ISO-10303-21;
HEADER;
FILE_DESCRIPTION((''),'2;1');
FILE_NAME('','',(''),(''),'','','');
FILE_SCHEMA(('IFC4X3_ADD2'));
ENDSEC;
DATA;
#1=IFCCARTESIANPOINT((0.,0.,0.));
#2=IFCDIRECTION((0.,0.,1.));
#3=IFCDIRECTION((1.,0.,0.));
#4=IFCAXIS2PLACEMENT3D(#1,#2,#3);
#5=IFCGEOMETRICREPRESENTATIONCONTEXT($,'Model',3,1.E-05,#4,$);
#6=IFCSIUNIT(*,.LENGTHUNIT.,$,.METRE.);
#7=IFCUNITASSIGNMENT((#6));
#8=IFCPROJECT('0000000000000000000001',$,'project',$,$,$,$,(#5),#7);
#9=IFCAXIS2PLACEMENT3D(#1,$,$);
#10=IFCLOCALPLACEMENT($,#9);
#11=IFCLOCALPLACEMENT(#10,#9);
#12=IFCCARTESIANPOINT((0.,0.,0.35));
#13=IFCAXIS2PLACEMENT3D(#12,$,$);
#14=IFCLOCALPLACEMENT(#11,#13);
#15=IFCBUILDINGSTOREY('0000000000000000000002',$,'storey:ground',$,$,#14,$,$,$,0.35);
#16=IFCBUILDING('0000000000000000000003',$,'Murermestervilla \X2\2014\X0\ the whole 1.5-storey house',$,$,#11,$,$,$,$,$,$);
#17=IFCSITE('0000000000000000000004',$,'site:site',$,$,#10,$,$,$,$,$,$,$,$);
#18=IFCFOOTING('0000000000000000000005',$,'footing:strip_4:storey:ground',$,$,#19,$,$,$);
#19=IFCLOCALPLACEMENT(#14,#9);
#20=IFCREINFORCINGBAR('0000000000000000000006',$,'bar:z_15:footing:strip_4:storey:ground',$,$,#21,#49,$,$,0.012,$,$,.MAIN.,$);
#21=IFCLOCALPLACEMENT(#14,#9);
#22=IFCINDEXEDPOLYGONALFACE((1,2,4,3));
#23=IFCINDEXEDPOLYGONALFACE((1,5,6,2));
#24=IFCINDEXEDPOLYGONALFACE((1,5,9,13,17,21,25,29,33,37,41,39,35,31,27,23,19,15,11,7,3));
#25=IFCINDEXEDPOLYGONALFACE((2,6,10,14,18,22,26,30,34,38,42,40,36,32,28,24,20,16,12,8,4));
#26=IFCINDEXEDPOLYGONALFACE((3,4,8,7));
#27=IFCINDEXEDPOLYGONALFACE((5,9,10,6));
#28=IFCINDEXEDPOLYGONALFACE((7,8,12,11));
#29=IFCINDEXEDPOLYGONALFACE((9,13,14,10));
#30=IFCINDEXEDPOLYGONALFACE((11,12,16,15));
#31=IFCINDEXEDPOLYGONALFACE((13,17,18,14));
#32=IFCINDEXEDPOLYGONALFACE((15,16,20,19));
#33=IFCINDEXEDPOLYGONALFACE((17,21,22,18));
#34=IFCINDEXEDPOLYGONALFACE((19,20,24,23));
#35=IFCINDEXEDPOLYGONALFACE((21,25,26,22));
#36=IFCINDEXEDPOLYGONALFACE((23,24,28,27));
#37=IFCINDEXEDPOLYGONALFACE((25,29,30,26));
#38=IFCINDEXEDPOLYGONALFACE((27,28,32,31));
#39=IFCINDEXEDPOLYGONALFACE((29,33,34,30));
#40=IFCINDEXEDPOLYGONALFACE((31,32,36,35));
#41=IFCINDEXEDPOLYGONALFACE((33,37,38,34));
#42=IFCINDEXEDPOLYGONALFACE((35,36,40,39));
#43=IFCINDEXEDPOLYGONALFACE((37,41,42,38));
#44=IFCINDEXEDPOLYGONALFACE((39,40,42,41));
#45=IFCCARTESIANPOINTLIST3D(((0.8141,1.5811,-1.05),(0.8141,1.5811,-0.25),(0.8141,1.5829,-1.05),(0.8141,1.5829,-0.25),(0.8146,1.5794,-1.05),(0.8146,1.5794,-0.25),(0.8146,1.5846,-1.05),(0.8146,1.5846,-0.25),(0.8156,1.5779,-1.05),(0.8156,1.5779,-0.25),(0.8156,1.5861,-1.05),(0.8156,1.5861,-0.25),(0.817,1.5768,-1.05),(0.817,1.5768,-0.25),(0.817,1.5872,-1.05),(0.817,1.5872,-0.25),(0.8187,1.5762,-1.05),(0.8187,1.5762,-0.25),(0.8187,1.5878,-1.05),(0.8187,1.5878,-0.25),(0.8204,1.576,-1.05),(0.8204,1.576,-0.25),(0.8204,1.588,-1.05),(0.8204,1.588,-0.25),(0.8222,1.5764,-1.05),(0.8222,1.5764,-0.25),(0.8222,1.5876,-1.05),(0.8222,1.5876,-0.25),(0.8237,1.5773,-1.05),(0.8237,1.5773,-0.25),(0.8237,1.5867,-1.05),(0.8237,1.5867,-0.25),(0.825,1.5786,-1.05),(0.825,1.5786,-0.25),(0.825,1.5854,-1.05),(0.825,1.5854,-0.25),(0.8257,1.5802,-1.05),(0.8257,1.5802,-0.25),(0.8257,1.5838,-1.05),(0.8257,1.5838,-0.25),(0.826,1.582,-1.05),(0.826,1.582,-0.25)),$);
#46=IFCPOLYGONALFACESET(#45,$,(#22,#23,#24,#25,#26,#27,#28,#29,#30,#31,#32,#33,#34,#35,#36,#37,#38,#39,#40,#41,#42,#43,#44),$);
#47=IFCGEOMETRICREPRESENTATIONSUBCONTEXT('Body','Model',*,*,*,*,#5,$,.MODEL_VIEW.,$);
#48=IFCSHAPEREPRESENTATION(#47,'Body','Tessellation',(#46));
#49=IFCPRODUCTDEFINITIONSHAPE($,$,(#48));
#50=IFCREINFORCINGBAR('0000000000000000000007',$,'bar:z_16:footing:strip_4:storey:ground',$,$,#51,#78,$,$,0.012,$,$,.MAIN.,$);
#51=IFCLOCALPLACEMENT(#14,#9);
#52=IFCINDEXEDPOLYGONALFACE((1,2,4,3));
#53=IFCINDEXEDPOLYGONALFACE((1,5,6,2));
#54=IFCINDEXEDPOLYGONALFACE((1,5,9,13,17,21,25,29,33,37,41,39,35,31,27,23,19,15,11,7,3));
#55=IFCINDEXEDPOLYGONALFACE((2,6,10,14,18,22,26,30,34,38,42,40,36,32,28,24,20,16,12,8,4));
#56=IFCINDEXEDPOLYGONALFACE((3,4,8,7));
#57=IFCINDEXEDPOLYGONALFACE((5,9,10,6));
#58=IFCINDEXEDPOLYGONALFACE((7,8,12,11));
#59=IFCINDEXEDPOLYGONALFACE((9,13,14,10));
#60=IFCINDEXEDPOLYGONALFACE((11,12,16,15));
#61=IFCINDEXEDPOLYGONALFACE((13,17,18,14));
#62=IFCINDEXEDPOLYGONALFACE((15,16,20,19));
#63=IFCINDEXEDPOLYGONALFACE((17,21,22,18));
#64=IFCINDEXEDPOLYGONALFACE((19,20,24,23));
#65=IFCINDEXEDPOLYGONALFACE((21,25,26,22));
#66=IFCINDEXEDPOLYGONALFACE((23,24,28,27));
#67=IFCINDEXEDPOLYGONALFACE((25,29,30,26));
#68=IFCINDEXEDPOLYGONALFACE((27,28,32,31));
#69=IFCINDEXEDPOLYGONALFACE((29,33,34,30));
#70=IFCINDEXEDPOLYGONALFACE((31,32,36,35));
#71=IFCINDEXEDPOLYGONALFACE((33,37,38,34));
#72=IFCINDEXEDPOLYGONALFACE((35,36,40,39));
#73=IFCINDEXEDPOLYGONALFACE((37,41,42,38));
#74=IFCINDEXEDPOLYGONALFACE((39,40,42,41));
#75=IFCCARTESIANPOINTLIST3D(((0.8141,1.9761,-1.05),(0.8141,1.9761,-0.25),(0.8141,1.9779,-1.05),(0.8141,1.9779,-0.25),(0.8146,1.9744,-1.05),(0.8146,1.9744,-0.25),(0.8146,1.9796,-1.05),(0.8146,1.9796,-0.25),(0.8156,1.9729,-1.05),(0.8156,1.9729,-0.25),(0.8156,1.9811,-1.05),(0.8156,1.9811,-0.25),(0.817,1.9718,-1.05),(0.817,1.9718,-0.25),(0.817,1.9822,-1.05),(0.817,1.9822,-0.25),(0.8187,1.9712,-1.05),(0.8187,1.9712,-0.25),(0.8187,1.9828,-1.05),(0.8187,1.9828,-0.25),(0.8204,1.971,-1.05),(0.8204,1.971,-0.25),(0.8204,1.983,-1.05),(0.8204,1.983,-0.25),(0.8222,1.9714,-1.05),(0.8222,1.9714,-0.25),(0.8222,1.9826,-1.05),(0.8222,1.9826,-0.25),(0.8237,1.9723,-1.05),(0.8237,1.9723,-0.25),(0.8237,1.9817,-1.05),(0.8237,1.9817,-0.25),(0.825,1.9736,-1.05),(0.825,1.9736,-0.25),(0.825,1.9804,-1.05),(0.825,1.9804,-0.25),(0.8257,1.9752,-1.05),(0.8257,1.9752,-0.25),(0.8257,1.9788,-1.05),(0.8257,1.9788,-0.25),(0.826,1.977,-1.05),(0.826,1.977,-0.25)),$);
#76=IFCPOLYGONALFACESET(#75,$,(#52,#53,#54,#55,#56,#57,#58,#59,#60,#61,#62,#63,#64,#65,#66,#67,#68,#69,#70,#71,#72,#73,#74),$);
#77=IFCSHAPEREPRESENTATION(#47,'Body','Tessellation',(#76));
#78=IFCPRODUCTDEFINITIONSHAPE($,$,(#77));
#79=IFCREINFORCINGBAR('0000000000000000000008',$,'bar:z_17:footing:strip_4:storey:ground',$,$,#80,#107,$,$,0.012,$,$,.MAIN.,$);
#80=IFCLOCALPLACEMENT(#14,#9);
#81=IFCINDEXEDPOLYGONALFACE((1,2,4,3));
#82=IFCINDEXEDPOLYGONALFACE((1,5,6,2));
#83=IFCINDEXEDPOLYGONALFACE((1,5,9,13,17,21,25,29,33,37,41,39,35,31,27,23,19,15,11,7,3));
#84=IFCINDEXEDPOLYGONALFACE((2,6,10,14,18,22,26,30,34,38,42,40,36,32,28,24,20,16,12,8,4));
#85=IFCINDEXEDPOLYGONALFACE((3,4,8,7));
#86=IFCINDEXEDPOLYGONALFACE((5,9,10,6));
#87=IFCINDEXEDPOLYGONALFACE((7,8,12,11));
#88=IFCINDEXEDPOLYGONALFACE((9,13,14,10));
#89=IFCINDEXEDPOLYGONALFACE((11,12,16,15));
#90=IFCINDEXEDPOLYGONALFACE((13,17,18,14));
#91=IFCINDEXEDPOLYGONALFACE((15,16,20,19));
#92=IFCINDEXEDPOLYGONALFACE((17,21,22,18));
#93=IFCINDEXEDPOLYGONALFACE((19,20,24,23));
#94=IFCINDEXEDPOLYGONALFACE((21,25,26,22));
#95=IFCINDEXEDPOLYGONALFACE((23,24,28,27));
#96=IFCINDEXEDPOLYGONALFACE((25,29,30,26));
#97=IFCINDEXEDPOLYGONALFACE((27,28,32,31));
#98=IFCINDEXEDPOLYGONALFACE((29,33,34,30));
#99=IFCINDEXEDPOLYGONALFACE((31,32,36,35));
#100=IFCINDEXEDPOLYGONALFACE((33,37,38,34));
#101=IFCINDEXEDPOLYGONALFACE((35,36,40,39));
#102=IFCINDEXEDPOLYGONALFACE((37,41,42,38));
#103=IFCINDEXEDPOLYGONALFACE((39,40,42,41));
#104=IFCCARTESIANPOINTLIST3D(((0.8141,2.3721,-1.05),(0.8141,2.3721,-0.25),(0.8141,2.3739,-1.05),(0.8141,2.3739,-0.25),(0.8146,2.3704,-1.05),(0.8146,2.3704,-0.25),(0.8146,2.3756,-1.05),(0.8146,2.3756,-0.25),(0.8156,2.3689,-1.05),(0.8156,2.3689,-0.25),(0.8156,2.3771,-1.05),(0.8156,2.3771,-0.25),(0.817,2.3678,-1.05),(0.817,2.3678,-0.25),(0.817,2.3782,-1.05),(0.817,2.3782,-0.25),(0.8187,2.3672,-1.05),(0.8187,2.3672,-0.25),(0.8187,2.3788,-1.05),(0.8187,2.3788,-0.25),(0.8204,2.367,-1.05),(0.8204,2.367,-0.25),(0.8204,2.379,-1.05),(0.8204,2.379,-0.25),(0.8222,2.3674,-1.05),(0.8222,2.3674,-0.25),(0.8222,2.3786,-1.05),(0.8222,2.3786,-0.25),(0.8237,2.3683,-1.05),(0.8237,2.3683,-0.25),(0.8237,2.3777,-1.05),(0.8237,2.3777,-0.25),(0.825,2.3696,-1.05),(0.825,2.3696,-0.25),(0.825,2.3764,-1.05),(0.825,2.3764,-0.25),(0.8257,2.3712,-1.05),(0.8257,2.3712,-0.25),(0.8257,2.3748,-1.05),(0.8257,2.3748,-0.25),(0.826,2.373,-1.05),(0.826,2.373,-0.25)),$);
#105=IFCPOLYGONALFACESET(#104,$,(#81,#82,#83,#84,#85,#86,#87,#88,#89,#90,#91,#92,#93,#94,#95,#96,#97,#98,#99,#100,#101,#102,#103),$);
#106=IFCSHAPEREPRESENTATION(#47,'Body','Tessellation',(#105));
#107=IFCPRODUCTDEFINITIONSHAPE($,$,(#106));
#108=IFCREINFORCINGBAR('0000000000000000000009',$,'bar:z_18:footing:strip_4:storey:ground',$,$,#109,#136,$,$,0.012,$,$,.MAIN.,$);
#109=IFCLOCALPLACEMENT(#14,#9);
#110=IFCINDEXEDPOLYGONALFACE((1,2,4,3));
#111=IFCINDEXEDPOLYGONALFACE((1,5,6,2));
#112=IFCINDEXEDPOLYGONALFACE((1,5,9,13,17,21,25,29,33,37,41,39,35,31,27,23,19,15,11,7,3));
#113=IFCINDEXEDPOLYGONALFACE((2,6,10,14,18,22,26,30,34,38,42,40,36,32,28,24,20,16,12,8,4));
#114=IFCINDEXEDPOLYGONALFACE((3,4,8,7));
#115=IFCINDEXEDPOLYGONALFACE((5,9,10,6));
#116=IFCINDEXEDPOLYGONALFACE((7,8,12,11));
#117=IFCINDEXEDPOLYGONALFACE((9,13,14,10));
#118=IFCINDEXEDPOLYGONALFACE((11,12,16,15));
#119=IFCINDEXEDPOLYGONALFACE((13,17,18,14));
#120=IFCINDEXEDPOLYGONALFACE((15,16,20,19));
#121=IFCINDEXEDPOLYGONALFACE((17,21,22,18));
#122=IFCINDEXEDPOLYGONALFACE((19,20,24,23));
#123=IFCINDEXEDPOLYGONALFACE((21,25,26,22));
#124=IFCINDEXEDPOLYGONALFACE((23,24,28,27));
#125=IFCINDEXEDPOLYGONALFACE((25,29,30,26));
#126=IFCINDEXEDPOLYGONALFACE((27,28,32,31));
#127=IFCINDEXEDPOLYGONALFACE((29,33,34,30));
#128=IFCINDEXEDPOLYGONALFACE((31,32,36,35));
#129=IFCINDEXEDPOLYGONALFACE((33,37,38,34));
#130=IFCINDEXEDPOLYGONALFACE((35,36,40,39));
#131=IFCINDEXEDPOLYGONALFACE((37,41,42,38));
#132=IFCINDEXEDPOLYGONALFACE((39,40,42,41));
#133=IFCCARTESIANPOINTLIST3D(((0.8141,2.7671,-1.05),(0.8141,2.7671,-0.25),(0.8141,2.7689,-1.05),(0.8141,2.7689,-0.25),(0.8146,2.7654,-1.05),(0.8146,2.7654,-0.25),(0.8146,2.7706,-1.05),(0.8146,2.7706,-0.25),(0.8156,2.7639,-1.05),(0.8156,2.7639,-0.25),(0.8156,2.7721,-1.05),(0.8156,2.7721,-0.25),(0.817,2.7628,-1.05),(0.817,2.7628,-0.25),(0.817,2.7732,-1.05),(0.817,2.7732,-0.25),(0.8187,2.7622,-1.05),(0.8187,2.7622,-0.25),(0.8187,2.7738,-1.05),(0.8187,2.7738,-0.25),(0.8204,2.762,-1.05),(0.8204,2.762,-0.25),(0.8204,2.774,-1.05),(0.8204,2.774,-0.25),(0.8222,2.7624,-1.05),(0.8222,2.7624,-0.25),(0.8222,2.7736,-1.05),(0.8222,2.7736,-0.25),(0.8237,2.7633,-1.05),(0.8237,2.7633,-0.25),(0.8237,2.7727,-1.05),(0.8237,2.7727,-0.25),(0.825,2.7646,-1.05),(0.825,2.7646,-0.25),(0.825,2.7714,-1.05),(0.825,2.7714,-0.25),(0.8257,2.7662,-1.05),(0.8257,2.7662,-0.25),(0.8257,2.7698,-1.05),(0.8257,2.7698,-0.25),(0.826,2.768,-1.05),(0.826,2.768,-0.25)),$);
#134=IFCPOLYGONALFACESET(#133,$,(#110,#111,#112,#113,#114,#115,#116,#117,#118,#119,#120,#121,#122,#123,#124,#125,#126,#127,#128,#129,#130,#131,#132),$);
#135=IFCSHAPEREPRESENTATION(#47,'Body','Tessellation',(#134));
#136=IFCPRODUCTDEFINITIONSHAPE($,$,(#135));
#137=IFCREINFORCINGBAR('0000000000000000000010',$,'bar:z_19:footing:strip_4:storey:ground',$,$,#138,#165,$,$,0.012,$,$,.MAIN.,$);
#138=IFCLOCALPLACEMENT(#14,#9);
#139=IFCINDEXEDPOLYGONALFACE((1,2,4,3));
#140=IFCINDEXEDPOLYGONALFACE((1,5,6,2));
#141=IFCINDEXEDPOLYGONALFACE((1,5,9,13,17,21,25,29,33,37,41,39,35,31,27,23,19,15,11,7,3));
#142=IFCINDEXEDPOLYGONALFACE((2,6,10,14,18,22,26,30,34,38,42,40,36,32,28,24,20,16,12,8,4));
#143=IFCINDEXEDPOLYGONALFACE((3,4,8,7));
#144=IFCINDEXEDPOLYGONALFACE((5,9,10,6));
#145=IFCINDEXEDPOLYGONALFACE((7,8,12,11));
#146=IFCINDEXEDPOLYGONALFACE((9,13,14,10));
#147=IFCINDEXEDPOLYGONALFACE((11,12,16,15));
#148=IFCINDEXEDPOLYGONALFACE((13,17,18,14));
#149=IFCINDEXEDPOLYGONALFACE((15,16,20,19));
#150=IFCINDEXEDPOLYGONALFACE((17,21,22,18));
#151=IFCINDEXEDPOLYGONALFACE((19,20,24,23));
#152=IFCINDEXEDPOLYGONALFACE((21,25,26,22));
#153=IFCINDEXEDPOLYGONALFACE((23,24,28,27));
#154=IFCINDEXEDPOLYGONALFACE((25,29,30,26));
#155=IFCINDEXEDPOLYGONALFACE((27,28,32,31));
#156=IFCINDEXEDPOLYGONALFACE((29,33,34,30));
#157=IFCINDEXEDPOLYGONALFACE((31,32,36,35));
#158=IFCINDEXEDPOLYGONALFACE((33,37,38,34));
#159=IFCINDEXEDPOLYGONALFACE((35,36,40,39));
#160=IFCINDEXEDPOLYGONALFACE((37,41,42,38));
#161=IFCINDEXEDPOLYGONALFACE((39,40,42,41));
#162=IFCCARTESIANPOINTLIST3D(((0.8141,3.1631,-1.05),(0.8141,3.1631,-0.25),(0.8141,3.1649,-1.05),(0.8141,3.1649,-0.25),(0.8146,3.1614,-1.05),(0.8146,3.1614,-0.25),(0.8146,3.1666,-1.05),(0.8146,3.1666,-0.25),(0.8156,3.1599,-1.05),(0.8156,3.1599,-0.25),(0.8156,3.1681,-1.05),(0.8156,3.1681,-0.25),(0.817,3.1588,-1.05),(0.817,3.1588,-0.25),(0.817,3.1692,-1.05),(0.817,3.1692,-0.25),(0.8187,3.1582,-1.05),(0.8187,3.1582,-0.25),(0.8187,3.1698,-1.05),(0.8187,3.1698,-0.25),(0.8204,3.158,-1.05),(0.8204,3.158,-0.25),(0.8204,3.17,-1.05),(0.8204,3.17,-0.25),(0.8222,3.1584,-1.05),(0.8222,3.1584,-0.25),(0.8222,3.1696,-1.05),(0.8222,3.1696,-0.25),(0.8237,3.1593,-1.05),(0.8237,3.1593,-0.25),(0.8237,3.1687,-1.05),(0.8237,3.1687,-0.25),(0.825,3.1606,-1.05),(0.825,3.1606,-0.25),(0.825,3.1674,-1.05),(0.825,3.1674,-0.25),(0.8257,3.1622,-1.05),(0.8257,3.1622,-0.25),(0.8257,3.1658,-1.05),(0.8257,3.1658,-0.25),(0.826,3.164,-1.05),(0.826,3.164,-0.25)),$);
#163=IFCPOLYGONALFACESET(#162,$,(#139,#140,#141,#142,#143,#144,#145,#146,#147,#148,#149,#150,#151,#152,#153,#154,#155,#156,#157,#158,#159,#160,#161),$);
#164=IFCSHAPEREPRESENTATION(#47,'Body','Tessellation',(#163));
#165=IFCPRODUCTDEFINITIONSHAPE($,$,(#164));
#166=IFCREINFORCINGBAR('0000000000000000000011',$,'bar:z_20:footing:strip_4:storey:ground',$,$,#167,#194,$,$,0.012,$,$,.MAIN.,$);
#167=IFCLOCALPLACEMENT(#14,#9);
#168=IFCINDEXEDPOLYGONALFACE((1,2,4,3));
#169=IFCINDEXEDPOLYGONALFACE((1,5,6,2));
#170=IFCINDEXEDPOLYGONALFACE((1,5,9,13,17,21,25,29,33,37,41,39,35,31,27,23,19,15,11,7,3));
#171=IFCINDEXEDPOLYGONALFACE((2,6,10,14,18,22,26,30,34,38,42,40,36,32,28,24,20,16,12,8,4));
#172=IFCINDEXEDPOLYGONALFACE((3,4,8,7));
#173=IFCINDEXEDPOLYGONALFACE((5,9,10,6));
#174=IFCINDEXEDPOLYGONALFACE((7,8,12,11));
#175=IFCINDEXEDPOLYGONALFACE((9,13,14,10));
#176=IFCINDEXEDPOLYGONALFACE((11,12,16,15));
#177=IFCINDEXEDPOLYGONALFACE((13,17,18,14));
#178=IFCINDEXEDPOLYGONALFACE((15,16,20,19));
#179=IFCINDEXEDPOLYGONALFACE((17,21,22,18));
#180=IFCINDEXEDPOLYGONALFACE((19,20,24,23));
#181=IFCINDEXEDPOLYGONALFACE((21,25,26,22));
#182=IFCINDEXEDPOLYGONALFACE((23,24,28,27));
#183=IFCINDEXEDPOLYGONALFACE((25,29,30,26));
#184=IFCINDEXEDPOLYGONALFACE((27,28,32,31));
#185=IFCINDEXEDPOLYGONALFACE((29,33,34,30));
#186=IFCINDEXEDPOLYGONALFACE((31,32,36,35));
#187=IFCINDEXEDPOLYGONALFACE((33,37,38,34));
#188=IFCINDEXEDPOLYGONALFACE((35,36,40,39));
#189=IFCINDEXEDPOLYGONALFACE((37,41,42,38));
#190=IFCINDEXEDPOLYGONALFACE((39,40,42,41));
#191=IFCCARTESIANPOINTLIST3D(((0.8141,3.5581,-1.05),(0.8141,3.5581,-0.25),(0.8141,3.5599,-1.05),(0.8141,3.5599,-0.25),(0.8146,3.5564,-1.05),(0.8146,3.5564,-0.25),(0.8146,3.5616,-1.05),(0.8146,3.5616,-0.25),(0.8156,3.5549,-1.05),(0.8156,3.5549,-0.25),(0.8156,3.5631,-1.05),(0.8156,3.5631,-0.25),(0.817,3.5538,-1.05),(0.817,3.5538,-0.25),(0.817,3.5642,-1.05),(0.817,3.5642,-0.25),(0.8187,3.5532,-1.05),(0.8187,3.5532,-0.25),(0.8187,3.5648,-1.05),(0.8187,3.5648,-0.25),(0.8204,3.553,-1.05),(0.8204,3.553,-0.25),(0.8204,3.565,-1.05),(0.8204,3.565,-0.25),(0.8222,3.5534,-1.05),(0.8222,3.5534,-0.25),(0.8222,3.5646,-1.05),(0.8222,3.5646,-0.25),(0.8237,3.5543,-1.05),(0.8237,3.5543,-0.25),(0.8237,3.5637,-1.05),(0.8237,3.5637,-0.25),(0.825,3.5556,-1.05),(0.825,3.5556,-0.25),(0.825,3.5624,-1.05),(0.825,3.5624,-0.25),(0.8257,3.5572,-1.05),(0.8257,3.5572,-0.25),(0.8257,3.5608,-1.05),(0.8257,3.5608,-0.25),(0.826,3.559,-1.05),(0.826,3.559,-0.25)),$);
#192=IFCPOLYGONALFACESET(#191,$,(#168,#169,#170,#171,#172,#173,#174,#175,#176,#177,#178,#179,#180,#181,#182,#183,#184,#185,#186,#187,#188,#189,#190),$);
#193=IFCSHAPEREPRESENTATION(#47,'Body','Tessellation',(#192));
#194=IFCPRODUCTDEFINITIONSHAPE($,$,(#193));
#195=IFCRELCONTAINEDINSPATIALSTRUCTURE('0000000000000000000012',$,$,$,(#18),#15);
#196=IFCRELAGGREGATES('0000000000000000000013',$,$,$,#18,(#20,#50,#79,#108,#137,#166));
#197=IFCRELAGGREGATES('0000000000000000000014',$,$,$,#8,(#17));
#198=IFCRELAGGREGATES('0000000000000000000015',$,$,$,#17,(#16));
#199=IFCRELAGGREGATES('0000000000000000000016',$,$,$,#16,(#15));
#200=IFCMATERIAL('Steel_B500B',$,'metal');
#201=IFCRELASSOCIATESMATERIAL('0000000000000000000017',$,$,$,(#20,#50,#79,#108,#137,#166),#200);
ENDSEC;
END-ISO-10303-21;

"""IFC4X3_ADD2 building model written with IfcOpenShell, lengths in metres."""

from ifc_helpers import new_model, entity, si_unit, frame, origin, origin_with_axes, place, context, subcontext, project, spatial, material, element, aggregate, save


model = new_model("IFC4X3_ADD2")

# Units and contexts
model_context = context("Model", 3, precision=1e-05, world=origin_with_axes())
body_context = subcontext(model_context, "Body", "Model", "MODEL_VIEW")
ifc_project = project(units=[si_unit("LENGTHUNIT", "METRE")], contexts=[model_context])

# Site, building, storey
placement_1 = place(None, origin())
site = spatial("IfcSite", under=ifc_project, at=placement_1, Name="site:site")
building_placement = place(placement_1, origin())
building = spatial("IfcBuilding", under=site, at=building_placement, Name="Murermestervilla — the whole 1.5-storey house")
storey_placement = place(building_placement, frame((0.0, 0.0, 0.35)))
storey = spatial("IfcBuildingStorey", under=building, at=storey_placement, Name="storey:ground", Elevation=0.35)

# Footing, reinforcing bars
placement_2 = place(storey_placement, frame((0.0, 0.0, -0.35)))
footing_1 = element("IfcFooting", 1, at=placement_2, inside=storey, Name="footing:strip_4:storey:ground")
ifc_material = material(Name="Steel_B500B", Category="metal")
reinforcing_bar_1 = element("IfcReinforcingBar", 2, at=placement_1, material=ifc_material, Name="bar:z_15:footing:strip_4:storey:ground", NominalDiameter=0.012, PredefinedType="MAIN", context=body_context, shape_type="AdvancedSweptSolid", body=[
    entity("IfcSweptDiskSolid", entity("IfcPolyline", [entity("IfcCartesianPoint", [0.82, 1.582, -0.7]), entity("IfcCartesianPoint", [0.82, 1.582, 0.1])]), 0.006),
])
reinforcing_bar_2 = element("IfcReinforcingBar", 3, at=placement_1, material=ifc_material, Name="bar:z_16:footing:strip_4:storey:ground", NominalDiameter=0.012, PredefinedType="MAIN", context=body_context, shape_type="AdvancedSweptSolid", body=[
    entity("IfcSweptDiskSolid", entity("IfcPolyline", [entity("IfcCartesianPoint", [0.82, 1.977, -0.7]), entity("IfcCartesianPoint", [0.82, 1.977, 0.1])]), 0.006),
])
reinforcing_bar_3 = element("IfcReinforcingBar", 4, at=placement_1, material=ifc_material, Name="bar:z_17:footing:strip_4:storey:ground", NominalDiameter=0.012, PredefinedType="MAIN", context=body_context, shape_type="AdvancedSweptSolid", body=[
    entity("IfcSweptDiskSolid", entity("IfcPolyline", [entity("IfcCartesianPoint", [0.82, 2.373, -0.7]), entity("IfcCartesianPoint", [0.82, 2.373, 0.1])]), 0.006),
])
reinforcing_bar_4 = element("IfcReinforcingBar", 5, at=placement_1, material=ifc_material, Name="bar:z_18:footing:strip_4:storey:ground", NominalDiameter=0.012, PredefinedType="MAIN", context=body_context, shape_type="AdvancedSweptSolid", body=[
    entity("IfcSweptDiskSolid", entity("IfcPolyline", [entity("IfcCartesianPoint", [0.82, 2.768, -0.7]), entity("IfcCartesianPoint", [0.82, 2.768, 0.1])]), 0.006),
])
reinforcing_bar_5 = element("IfcReinforcingBar", 6, at=placement_1, material=ifc_material, Name="bar:z_19:footing:strip_4:storey:ground", NominalDiameter=0.012, PredefinedType="MAIN", context=body_context, shape_type="AdvancedSweptSolid", body=[
    entity("IfcSweptDiskSolid", entity("IfcPolyline", [entity("IfcCartesianPoint", [0.82, 3.164, -0.7]), entity("IfcCartesianPoint", [0.82, 3.164, 0.1])]), 0.006),
])
reinforcing_bar_6 = element("IfcReinforcingBar", 7, at=placement_1, material=ifc_material, Name="bar:z_20:footing:strip_4:storey:ground", NominalDiameter=0.012, PredefinedType="MAIN", context=body_context, shape_type="AdvancedSweptSolid", body=[
    entity("IfcSweptDiskSolid", entity("IfcPolyline", [entity("IfcCartesianPoint", [0.82, 3.559, -0.7]), entity("IfcCartesianPoint", [0.82, 3.559, 0.1])]), 0.006),
])
aggregate(footing_1, [reinforcing_bar_1, reinforcing_bar_2, reinforcing_bar_3, reinforcing_bar_4, reinforcing_bar_5, reinforcing_bar_6])

save(model, "model.ifc")
